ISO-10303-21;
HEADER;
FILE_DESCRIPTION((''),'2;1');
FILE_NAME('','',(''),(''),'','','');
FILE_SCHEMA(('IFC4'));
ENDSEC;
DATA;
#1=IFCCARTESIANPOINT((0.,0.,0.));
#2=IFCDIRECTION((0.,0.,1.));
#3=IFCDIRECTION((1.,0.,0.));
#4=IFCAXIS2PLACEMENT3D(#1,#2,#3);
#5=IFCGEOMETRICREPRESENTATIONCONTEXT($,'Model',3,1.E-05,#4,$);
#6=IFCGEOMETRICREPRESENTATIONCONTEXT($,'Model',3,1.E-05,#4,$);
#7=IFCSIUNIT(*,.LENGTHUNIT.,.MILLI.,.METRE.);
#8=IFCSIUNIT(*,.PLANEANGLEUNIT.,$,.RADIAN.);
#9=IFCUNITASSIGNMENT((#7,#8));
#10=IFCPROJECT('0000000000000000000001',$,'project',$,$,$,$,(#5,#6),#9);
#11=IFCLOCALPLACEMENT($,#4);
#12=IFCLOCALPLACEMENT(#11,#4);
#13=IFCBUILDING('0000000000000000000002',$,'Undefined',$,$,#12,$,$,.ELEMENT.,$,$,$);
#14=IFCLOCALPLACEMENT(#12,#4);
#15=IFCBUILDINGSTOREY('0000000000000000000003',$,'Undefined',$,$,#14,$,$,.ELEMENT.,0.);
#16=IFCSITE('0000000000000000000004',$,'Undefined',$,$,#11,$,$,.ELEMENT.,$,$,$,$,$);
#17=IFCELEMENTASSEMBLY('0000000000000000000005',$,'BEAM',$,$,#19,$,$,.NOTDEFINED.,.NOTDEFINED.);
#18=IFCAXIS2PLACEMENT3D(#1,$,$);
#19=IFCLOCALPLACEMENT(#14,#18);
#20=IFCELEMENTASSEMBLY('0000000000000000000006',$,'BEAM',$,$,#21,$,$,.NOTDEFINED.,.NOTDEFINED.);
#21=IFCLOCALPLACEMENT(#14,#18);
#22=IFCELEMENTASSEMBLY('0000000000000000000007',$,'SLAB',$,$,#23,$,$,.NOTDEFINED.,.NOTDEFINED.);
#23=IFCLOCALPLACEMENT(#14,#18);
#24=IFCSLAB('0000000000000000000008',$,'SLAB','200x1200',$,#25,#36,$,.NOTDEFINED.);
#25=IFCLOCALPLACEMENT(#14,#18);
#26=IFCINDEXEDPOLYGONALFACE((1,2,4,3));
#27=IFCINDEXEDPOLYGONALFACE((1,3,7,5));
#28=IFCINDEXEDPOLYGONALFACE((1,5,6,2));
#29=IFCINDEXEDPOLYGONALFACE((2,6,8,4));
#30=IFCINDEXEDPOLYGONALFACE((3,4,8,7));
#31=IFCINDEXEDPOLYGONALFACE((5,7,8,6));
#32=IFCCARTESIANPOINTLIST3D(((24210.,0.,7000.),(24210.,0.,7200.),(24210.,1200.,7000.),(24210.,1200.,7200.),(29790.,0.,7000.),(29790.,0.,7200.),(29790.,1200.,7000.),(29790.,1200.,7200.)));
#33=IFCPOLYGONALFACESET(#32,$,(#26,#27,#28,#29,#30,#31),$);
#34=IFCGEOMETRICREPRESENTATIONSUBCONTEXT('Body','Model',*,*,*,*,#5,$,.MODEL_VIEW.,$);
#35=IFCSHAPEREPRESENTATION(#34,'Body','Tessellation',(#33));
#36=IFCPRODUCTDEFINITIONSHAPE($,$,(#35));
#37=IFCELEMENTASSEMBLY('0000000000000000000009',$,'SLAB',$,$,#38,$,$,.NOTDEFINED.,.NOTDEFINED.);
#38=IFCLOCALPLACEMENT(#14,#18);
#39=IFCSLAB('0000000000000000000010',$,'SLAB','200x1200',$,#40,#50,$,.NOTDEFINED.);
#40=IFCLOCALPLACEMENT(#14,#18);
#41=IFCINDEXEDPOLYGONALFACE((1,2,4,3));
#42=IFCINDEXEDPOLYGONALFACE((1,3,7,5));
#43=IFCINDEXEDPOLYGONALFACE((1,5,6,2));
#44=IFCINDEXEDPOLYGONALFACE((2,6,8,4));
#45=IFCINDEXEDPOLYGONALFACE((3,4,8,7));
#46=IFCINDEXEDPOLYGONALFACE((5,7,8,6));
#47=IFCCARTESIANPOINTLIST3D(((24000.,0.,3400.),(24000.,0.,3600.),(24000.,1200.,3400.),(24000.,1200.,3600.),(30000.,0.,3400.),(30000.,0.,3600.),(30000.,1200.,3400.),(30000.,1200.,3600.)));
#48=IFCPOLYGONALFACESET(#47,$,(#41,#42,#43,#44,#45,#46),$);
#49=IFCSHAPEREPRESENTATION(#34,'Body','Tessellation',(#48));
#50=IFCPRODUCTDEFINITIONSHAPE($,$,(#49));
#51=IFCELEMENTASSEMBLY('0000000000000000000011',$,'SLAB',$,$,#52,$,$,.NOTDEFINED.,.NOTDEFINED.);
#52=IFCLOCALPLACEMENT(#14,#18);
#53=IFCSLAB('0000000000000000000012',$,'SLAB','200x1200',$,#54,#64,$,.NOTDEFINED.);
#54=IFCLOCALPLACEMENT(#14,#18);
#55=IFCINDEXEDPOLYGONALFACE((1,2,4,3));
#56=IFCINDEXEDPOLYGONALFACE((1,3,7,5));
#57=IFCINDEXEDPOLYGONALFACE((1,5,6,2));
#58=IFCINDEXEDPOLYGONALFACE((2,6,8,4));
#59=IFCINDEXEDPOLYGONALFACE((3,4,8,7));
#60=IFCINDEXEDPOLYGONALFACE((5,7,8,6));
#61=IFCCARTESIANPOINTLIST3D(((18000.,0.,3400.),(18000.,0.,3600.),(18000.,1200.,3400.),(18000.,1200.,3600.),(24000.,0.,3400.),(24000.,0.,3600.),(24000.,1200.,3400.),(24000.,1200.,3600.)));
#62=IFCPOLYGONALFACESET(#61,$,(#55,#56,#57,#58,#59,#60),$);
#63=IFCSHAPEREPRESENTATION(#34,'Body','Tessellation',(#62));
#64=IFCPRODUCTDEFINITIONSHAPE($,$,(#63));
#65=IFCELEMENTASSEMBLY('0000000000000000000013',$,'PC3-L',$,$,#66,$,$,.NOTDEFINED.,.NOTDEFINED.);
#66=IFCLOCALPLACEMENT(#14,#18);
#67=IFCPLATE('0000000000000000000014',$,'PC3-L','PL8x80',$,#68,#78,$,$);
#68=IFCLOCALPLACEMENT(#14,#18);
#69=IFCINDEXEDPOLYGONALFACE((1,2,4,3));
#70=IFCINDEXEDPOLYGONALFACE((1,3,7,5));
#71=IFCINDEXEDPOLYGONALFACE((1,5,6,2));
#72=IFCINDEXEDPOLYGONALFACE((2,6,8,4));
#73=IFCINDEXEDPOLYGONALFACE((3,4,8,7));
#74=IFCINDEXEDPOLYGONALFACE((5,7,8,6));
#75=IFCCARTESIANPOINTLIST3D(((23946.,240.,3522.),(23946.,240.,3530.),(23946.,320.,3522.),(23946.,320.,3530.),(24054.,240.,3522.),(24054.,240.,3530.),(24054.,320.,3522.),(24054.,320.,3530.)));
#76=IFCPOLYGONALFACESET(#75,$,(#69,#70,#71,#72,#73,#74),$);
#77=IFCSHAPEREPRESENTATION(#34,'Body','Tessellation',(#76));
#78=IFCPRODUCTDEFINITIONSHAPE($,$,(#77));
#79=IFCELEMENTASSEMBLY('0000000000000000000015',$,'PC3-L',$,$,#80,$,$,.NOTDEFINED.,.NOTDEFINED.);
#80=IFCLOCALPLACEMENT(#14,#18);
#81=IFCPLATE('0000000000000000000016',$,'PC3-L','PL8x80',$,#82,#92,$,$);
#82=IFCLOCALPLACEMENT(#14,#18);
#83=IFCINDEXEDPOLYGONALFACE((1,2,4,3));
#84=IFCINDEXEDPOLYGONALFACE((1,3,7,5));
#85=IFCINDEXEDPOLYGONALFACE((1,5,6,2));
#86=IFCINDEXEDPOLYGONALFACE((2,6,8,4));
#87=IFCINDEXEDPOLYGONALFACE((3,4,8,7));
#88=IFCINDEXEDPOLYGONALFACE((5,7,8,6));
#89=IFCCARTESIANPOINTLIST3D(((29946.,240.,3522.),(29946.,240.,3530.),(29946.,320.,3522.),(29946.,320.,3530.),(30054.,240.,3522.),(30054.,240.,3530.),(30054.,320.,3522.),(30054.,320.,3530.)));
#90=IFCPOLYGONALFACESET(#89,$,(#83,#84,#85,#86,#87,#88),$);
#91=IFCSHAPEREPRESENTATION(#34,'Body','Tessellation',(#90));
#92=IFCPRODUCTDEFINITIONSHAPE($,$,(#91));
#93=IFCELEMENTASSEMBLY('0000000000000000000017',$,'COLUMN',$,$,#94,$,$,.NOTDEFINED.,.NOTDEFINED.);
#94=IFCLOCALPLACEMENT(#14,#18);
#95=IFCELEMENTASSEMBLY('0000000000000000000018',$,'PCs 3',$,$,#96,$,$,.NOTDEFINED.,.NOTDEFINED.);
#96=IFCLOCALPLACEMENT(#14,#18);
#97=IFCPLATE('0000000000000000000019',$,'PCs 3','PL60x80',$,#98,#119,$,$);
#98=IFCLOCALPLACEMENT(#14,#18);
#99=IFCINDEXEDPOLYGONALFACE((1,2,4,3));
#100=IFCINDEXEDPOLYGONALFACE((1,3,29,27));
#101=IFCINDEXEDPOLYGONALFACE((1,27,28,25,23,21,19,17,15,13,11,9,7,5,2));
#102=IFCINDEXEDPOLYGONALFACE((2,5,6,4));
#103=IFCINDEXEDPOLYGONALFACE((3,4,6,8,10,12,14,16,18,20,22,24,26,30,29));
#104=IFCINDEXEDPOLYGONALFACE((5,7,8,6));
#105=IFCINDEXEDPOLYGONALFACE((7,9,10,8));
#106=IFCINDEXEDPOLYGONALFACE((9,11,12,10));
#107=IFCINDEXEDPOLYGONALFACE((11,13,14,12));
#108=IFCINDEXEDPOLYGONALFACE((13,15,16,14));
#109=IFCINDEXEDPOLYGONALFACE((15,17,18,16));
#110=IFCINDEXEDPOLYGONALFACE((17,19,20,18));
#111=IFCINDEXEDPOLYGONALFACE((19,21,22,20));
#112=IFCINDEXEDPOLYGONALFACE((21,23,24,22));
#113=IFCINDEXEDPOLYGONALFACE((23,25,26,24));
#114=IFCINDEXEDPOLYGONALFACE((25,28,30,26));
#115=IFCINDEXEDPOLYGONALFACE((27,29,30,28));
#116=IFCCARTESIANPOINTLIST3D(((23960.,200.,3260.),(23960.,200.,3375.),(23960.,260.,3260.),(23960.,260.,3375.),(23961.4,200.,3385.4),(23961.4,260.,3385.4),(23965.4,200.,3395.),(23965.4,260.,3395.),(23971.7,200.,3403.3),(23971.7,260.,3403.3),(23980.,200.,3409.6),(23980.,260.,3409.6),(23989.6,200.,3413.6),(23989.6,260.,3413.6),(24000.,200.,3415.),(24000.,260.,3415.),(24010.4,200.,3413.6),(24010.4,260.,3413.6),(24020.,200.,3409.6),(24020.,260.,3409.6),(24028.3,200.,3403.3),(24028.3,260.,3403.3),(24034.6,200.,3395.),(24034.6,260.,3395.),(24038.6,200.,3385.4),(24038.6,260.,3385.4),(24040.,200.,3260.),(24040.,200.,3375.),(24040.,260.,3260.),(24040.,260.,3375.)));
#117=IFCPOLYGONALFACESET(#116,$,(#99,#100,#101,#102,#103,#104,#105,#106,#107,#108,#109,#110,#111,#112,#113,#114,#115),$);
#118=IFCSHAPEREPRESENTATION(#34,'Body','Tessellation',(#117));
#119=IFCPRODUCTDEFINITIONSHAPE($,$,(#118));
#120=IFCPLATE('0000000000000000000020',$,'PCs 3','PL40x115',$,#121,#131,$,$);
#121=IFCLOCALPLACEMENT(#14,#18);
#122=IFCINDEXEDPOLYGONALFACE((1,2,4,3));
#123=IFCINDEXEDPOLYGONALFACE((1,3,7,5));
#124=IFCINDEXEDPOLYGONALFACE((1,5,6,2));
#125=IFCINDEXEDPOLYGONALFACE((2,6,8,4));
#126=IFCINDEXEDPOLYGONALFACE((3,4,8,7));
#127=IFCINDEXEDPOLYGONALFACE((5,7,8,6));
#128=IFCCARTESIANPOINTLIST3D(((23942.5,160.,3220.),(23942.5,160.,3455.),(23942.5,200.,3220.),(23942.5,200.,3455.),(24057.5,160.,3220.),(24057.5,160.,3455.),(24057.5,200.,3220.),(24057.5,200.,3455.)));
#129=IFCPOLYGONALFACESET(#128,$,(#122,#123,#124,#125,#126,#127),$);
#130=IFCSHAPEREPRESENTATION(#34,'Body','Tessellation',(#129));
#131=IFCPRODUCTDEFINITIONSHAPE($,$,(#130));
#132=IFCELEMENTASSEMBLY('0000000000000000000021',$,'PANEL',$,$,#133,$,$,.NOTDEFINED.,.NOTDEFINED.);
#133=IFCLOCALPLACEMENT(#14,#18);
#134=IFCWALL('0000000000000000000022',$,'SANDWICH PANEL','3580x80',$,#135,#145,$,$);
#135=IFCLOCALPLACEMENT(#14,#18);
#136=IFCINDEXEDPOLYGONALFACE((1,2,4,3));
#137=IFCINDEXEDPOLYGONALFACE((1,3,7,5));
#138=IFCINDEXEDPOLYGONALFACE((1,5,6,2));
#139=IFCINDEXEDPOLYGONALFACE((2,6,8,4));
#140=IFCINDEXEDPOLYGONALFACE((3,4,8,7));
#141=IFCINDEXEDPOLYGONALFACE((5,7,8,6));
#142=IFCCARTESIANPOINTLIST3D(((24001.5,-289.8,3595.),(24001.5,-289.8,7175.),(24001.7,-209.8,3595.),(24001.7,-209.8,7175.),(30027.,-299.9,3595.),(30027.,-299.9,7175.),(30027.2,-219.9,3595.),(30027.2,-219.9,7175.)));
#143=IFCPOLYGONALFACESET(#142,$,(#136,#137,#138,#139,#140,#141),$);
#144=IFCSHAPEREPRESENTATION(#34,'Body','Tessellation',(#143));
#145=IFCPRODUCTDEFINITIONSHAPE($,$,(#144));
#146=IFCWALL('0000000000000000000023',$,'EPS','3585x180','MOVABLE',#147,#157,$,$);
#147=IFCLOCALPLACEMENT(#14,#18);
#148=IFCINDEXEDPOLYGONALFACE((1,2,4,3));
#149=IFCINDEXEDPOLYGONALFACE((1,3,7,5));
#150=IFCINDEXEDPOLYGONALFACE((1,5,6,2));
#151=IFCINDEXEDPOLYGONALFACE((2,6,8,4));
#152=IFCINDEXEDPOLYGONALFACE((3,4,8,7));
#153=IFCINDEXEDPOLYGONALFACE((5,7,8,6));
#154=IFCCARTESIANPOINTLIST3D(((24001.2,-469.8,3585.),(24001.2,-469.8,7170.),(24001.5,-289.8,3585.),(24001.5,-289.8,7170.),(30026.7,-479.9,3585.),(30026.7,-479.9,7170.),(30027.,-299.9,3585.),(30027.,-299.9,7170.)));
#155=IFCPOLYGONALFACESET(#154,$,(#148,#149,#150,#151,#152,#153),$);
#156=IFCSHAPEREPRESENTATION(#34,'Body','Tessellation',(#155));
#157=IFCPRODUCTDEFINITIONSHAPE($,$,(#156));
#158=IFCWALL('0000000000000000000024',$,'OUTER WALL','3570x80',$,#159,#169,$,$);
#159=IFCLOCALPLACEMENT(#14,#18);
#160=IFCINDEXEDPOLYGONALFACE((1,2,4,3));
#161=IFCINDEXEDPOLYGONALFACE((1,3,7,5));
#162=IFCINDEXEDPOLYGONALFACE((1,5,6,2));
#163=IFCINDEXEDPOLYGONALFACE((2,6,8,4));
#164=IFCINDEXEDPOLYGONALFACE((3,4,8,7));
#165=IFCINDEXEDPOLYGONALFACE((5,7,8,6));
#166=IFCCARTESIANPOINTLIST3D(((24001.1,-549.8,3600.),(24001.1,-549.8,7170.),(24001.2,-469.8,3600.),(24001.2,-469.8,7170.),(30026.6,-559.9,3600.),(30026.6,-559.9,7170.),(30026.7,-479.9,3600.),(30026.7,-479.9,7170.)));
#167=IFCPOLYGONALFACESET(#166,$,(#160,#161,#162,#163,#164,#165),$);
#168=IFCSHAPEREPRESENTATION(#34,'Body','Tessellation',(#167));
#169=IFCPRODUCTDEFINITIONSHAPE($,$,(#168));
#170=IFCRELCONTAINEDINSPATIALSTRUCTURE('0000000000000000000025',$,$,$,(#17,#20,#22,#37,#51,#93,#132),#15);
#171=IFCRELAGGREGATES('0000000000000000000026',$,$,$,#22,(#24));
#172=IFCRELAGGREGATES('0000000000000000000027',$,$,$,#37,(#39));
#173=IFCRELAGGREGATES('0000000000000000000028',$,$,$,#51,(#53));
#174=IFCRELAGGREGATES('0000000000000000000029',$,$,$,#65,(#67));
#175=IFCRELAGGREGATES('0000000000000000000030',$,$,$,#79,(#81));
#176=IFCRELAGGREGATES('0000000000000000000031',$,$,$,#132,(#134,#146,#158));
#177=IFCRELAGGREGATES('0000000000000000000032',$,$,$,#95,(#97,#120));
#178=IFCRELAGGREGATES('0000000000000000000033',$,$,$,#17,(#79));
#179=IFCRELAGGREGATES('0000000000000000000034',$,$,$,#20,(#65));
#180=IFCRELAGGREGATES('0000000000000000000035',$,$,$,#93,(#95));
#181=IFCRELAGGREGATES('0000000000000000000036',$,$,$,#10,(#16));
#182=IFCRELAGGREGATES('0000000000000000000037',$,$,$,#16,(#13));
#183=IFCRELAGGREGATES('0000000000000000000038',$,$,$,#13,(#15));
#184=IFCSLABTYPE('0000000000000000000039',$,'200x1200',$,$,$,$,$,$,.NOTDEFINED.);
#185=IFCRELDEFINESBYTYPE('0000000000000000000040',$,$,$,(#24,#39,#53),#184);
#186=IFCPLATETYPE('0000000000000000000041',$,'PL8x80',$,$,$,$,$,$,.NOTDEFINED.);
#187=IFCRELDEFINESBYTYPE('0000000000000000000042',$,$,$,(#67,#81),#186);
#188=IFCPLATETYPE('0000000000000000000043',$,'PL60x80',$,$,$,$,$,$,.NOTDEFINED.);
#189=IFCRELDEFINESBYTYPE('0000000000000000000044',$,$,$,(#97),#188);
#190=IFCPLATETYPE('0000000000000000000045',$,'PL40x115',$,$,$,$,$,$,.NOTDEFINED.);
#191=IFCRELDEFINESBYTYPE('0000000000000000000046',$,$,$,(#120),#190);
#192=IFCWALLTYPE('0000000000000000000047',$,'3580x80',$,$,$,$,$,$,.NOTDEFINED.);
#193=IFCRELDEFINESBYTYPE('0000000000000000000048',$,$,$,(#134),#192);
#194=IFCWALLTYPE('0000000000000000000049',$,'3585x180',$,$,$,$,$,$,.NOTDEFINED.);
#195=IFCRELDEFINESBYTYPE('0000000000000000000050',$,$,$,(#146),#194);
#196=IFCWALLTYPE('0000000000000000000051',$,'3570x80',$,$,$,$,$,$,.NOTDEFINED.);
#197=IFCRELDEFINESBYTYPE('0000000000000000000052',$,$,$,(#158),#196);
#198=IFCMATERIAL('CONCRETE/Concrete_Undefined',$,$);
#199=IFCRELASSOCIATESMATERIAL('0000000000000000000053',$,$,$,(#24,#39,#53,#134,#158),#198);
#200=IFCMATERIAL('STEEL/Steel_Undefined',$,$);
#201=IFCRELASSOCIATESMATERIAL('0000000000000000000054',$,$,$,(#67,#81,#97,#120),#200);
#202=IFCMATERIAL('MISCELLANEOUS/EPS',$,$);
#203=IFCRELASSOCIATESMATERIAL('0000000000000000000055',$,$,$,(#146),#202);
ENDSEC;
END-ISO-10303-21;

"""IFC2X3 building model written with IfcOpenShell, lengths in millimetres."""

from ifc_helpers import new_model, si_unit, frame, frame_2d, origin_with_axes, place, context, subcontext, project, spatial, polyline, circle_curve, parameter, trimmed, segment, composite_curve, rectangle, outline, extrude, material, type_object, element, aggregate, save


model = new_model("IFC2X3")

# Units and contexts
model_context_1 = context("Model", 3, precision=1e-05, world=origin_with_axes())
model_context_2 = context("Model", 3, precision=1e-05, world=origin_with_axes())
body_context = subcontext(model_context_1, "Body", "Model", "MODEL_VIEW")
ifc_project = project(units=[si_unit("LENGTHUNIT", "METRE", prefix="MILLI"), si_unit("PLANEANGLEUNIT", "RADIAN")], contexts=[model_context_1, model_context_2])

# Site, building, storey
site_placement = place(None, origin_with_axes())
site = spatial("IfcSite", under=ifc_project, at=site_placement, Name="Undefined", CompositionType="ELEMENT")
building_placement = place(site_placement, origin_with_axes())
building = spatial("IfcBuilding", under=site, at=building_placement, Name="Undefined", CompositionType="ELEMENT")
storey_placement = place(building_placement, origin_with_axes())
storey = spatial("IfcBuildingStorey", under=building, at=storey_placement, Name="Undefined", CompositionType="ELEMENT", Elevation=0.0)

# Element assemblies
assembly_1_placement = place(storey_placement, origin_with_axes())
assembly_1 = element("IfcElementAssembly", 1, at=assembly_1_placement, inside=storey, Name="BEAM", AssemblyPlace="NOTDEFINED", PredefinedType="NOTDEFINED")
ifc_material_1 = material(Name="CONCRETE/Concrete_Undefined")
assembly_2_placement = place(storey_placement, origin_with_axes())
assembly_2 = element("IfcElementAssembly", 2, at=assembly_2_placement, inside=storey, Name="BEAM", AssemblyPlace="NOTDEFINED", PredefinedType="NOTDEFINED")

# Element assemblies, slabs
assembly_3_placement = place(storey_placement, origin_with_axes())
assembly_3 = element("IfcElementAssembly", 3, at=assembly_3_placement, inside=storey, Name="SLAB", AssemblyPlace="NOTDEFINED", PredefinedType="NOTDEFINED")
slab_type = type_object("IfcSlabType", Name="200x1200", PredefinedType="NOTDEFINED")
slab_1_placement = place(assembly_3_placement, frame((29790.0, 0.0, 7100.0), z_axis=(0.0, 0.0, 1.0), x_axis=(0.0, 1.0, 0.0)))
slab_1 = element("IfcSlab", 4, at=slab_1_placement, type_object=slab_type, material=ifc_material_1, Name="SLAB", Description="200x1200", PredefinedType="NOTDEFINED", context=body_context, shape_type="SweptSolid", body=[
    extrude(outline(polyline([(0.0, 0.0), (1200.0, 0.0), (1200.0, 5580.0), (0.0, 5580.0), (0.0, 0.0)])), frame((0.0, 0.0, -100.0), z_axis=(0.0, 0.0, 1.0), x_axis=(1.0, 0.0, 0.0)), (0.0, 0.0, 1.0), 200.0),
])
aggregate(assembly_3, [slab_1])
assembly_4_placement = place(storey_placement, origin_with_axes())
assembly_4 = element("IfcElementAssembly", 5, at=assembly_4_placement, inside=storey, Name="SLAB", AssemblyPlace="NOTDEFINED", PredefinedType="NOTDEFINED")
slab_2_placement = place(assembly_4_placement, frame((30000.0, 0.0, 3500.0), z_axis=(0.0, 0.0, 1.0), x_axis=(0.0, 1.0, 0.0)))
slab_2 = element("IfcSlab", 6, at=slab_2_placement, type_object=slab_type, material=ifc_material_1, Name="SLAB", Description="200x1200", PredefinedType="NOTDEFINED", context=body_context, shape_type="SweptSolid", body=[
    extrude(outline(polyline([(0.0, 0.0), (1200.0, 0.0), (1200.0, 6000.0), (0.0, 6000.0), (0.0, 0.0)])), frame((0.0, 0.0, -100.0), z_axis=(0.0, 0.0, 1.0), x_axis=(1.0, 0.0, 0.0)), (0.0, 0.0, 1.0), 200.0),
])
aggregate(assembly_4, [slab_2])
assembly_5_placement = place(storey_placement, origin_with_axes())
assembly_5 = element("IfcElementAssembly", 7, at=assembly_5_placement, inside=storey, Name="SLAB", AssemblyPlace="NOTDEFINED", PredefinedType="NOTDEFINED")
slab_3_placement = place(assembly_5_placement, frame((24000.0, 0.0, 3500.0), z_axis=(0.0, 0.0, 1.0), x_axis=(0.0, 1.0, 0.0)))
slab_3 = element("IfcSlab", 8, at=slab_3_placement, type_object=slab_type, material=ifc_material_1, Name="SLAB", Description="200x1200", PredefinedType="NOTDEFINED", context=body_context, shape_type="SweptSolid", body=[
    extrude(outline(polyline([(0.0, 0.0), (1200.0, 0.0), (1200.0, 6000.0), (0.0, 6000.0), (0.0, 0.0)])), frame((0.0, 0.0, -100.0), z_axis=(0.0, 0.0, 1.0), x_axis=(1.0, 0.0, 0.0)), (0.0, 0.0, 1.0), 200.0),
])
aggregate(assembly_5, [slab_3])

# Element assemblies, plates
assembly_6_placement = place(assembly_2_placement, origin_with_axes())
assembly_6 = element("IfcElementAssembly", 9, at=assembly_6_placement, Name="PC3-L", AssemblyPlace="NOTDEFINED", PredefinedType="NOTDEFINED")
ifc_material_2 = material(Name="STEEL/Steel_Undefined")
plate_type_1 = type_object("IfcPlateType", Name="PL8x80", PredefinedType="NOTDEFINED")
plate_1_placement = place(assembly_6_placement, frame((23946.0, 240.0, 3526.0), z_axis=(0.0, 0.0, 1.0), x_axis=(1.0, 0.0, 0.0)))
plate_1 = element("IfcPlate", 10, at=plate_1_placement, type_object=plate_type_1, material=ifc_material_2, Name="PC3-L", Description="PL8x80", context=body_context, shape_type="SweptSolid", body=[
    extrude(outline(polyline([(0.0, 0.0), (108.0, 0.0), (108.0, 80.0), (0.0, 80.0), (0.0, 0.0)])), frame((0.0, 0.0, -4.0), z_axis=(0.0, 0.0, 1.0), x_axis=(1.0, 0.0, 0.0)), (0.0, 0.0, 1.0), 8.0),
])
aggregate(assembly_6, [plate_1])
assembly_7_placement = place(assembly_1_placement, origin_with_axes())
assembly_7 = element("IfcElementAssembly", 11, at=assembly_7_placement, Name="PC3-L", AssemblyPlace="NOTDEFINED", PredefinedType="NOTDEFINED")
plate_2_placement = place(assembly_7_placement, frame((29946.0, 240.0, 3526.0), z_axis=(0.0, 0.0, 1.0), x_axis=(1.0, 0.0, 0.0)))
plate_2 = element("IfcPlate", 12, at=plate_2_placement, type_object=plate_type_1, material=ifc_material_2, Name="PC3-L", Description="PL8x80", context=body_context, shape_type="SweptSolid", body=[
    extrude(outline(polyline([(0.0, 0.0), (108.0, 0.0), (108.0, 80.0), (0.0, 80.0), (0.0, 0.0)])), frame((0.0, 0.0, -4.0), z_axis=(0.0, 0.0, 1.0), x_axis=(1.0, 0.0, 0.0)), (0.0, 0.0, 1.0), 8.0),
])
aggregate(assembly_7, [plate_2])

# Element assemblies, plates
assembly_8_placement = place(storey_placement, origin_with_axes())
assembly_8 = element("IfcElementAssembly", 13, at=assembly_8_placement, inside=storey, Name="COLUMN", AssemblyPlace="NOTDEFINED", PredefinedType="NOTDEFINED")
assembly_9_placement = place(assembly_8_placement, origin_with_axes())
assembly_9 = element("IfcElementAssembly", 14, at=assembly_9_placement, Name="PCs 3", AssemblyPlace="NOTDEFINED", PredefinedType="NOTDEFINED")
plate_type_2 = type_object("IfcPlateType", Name="PL60x80", PredefinedType="NOTDEFINED")
plate_3_placement = place(assembly_9_placement, frame((24040.0, 230.0, 3415.0), z_axis=(0.0, 1.0, 0.0), x_axis=(0.0, 0.0, -1.0)))
plate_3 = element("IfcPlate", 15, at=plate_3_placement, type_object=plate_type_2, material=ifc_material_2, Name="PCs 3", Description="PL60x80", context=body_context, shape_type="SweptSolid", body=[
    extrude(outline(composite_curve([segment(trimmed(circle_curve(frame_2d((40.0, 40.0), x_axis=(-1.0, 0.0)), 40.0), [parameter(0.0)], [parameter(1.570796)], True, "PARAMETER"), True, "CONTINUOUS"), segment(polyline([(40.0, 0.0), (155.0, 0.0), (155.0, 80.0), (40.0, 80.0)]), True, "CONTINUOUS"), segment(trimmed(circle_curve(frame_2d((40.0, 40.0), x_axis=(0.0, 1.0)), 40.0), [parameter(0.0)], [parameter(1.570796)], True, "PARAMETER"), True, "CONTINUOUS"), segment(polyline([(0.0, 40.0), (0.0, 40.0)]), True, "CONTINUOUS")], self_intersect=True)), frame((0.0, 0.0, -30.0), z_axis=(0.0, 0.0, 1.0), x_axis=(1.0, 0.0, 0.0)), (0.0, 0.0, 1.0), 60.0),
])
plate_type_3 = type_object("IfcPlateType", Name="PL40x115", PredefinedType="NOTDEFINED")
plate_4_placement = place(assembly_9_placement, frame((24057.5, 180.0, 3455.0), z_axis=(0.0, 1.0, 0.0), x_axis=(0.0, 0.0, -1.0)))
plate_4 = element("IfcPlate", 16, at=plate_4_placement, type_object=plate_type_3, material=ifc_material_2, Name="PCs 3", Description="PL40x115", context=body_context, shape_type="SweptSolid", body=[
    extrude(outline(polyline([(0.0, 0.0), (235.0, 0.0), (235.0, 115.0), (0.0, 115.0), (0.0, 0.0)])), frame((0.0, 0.0, -20.0), z_axis=(0.0, 0.0, 1.0), x_axis=(1.0, 0.0, 0.0)), (0.0, 0.0, 1.0), 40.0),
])

# Element assembly, walls
assembly_10_placement = place(storey_placement, origin_with_axes())
assembly_10 = element("IfcElementAssembly", 17, at=assembly_10_placement, inside=storey, Name="PANEL", AssemblyPlace="NOTDEFINED", PredefinedType="NOTDEFINED")
wall_type_1 = type_object("IfcWallType", Name="3580x80", PredefinedType="NOTDEFINED")
wall_1_placement = place(assembly_10_placement, frame((24001.6, -249.8, 3595.0), z_axis=(0.0, 0.0, 1.0), x_axis=(0.999999, -0.001684, 0.0)))
wall_1 = element("IfcWall", 18, at=wall_1_placement, type_object=wall_type_1, material=ifc_material_1, Name="SANDWICH PANEL", Description="3580x80", context=body_context, shape_type="SweptSolid", body=[
    extrude(rectangle(XDim=6025.5, YDim=80.0, at=frame_2d((0.0, 3012.8), x_axis=(0.0, -1.0))), frame((0.0, 0.0, 0.0), z_axis=(0.0, 0.0, 1.0), x_axis=(0.0, -1.0, 0.0)), (0.0, 0.0, 1.0), 3580.0),
])
ifc_material_3 = material(Name="MISCELLANEOUS/EPS")
wall_type_2 = type_object("IfcWallType", Name="3585x180", PredefinedType="NOTDEFINED")
wall_2_placement = place(assembly_10_placement, frame((24001.4, -379.8, 3585.0), z_axis=(0.0, 0.0, 1.0), x_axis=(0.999999, -0.001684, 0.0)))
wall_2 = element("IfcWall", 19, at=wall_2_placement, type_object=wall_type_2, material=ifc_material_3, Name="EPS", Description="3585x180", ObjectType="MOVABLE", context=body_context, shape_type="SweptSolid", body=[
    extrude(rectangle(XDim=6025.5, YDim=180.0, at=frame_2d((0.0, 3012.8), x_axis=(0.0, -1.0))), frame((0.0, 0.0, 0.0), z_axis=(0.0, 0.0, 1.0), x_axis=(0.0, -1.0, 0.0)), (0.0, 0.0, 1.0), 3585.0),
])
wall_type_3 = type_object("IfcWallType", Name="3570x80", PredefinedType="NOTDEFINED")
wall_3_placement = place(assembly_10_placement, frame((24001.2, -509.8, 3600.0), z_axis=(0.0, 0.0, 1.0), x_axis=(0.999999, -0.001684, 0.0)))
wall_3 = element("IfcWall", 20, at=wall_3_placement, type_object=wall_type_3, material=ifc_material_1, Name="OUTER WALL", Description="3570x80", context=body_context, shape_type="SweptSolid", body=[
    extrude(rectangle(XDim=6025.5, YDim=80.0, at=frame_2d((0.0, 3012.8), x_axis=(0.0, -1.0))), frame((0.0, 0.0, 0.0), z_axis=(0.0, 0.0, 1.0), x_axis=(0.0, -1.0, 0.0)), (0.0, 0.0, 1.0), 3570.0),
])
aggregate(assembly_10, [wall_1, wall_2, wall_3])

aggregate(assembly_9, [plate_3, plate_4])

aggregate(assembly_1, [assembly_7])
aggregate(assembly_2, [assembly_6])
aggregate(assembly_8, [assembly_9])

save(model, "model.ifc")
